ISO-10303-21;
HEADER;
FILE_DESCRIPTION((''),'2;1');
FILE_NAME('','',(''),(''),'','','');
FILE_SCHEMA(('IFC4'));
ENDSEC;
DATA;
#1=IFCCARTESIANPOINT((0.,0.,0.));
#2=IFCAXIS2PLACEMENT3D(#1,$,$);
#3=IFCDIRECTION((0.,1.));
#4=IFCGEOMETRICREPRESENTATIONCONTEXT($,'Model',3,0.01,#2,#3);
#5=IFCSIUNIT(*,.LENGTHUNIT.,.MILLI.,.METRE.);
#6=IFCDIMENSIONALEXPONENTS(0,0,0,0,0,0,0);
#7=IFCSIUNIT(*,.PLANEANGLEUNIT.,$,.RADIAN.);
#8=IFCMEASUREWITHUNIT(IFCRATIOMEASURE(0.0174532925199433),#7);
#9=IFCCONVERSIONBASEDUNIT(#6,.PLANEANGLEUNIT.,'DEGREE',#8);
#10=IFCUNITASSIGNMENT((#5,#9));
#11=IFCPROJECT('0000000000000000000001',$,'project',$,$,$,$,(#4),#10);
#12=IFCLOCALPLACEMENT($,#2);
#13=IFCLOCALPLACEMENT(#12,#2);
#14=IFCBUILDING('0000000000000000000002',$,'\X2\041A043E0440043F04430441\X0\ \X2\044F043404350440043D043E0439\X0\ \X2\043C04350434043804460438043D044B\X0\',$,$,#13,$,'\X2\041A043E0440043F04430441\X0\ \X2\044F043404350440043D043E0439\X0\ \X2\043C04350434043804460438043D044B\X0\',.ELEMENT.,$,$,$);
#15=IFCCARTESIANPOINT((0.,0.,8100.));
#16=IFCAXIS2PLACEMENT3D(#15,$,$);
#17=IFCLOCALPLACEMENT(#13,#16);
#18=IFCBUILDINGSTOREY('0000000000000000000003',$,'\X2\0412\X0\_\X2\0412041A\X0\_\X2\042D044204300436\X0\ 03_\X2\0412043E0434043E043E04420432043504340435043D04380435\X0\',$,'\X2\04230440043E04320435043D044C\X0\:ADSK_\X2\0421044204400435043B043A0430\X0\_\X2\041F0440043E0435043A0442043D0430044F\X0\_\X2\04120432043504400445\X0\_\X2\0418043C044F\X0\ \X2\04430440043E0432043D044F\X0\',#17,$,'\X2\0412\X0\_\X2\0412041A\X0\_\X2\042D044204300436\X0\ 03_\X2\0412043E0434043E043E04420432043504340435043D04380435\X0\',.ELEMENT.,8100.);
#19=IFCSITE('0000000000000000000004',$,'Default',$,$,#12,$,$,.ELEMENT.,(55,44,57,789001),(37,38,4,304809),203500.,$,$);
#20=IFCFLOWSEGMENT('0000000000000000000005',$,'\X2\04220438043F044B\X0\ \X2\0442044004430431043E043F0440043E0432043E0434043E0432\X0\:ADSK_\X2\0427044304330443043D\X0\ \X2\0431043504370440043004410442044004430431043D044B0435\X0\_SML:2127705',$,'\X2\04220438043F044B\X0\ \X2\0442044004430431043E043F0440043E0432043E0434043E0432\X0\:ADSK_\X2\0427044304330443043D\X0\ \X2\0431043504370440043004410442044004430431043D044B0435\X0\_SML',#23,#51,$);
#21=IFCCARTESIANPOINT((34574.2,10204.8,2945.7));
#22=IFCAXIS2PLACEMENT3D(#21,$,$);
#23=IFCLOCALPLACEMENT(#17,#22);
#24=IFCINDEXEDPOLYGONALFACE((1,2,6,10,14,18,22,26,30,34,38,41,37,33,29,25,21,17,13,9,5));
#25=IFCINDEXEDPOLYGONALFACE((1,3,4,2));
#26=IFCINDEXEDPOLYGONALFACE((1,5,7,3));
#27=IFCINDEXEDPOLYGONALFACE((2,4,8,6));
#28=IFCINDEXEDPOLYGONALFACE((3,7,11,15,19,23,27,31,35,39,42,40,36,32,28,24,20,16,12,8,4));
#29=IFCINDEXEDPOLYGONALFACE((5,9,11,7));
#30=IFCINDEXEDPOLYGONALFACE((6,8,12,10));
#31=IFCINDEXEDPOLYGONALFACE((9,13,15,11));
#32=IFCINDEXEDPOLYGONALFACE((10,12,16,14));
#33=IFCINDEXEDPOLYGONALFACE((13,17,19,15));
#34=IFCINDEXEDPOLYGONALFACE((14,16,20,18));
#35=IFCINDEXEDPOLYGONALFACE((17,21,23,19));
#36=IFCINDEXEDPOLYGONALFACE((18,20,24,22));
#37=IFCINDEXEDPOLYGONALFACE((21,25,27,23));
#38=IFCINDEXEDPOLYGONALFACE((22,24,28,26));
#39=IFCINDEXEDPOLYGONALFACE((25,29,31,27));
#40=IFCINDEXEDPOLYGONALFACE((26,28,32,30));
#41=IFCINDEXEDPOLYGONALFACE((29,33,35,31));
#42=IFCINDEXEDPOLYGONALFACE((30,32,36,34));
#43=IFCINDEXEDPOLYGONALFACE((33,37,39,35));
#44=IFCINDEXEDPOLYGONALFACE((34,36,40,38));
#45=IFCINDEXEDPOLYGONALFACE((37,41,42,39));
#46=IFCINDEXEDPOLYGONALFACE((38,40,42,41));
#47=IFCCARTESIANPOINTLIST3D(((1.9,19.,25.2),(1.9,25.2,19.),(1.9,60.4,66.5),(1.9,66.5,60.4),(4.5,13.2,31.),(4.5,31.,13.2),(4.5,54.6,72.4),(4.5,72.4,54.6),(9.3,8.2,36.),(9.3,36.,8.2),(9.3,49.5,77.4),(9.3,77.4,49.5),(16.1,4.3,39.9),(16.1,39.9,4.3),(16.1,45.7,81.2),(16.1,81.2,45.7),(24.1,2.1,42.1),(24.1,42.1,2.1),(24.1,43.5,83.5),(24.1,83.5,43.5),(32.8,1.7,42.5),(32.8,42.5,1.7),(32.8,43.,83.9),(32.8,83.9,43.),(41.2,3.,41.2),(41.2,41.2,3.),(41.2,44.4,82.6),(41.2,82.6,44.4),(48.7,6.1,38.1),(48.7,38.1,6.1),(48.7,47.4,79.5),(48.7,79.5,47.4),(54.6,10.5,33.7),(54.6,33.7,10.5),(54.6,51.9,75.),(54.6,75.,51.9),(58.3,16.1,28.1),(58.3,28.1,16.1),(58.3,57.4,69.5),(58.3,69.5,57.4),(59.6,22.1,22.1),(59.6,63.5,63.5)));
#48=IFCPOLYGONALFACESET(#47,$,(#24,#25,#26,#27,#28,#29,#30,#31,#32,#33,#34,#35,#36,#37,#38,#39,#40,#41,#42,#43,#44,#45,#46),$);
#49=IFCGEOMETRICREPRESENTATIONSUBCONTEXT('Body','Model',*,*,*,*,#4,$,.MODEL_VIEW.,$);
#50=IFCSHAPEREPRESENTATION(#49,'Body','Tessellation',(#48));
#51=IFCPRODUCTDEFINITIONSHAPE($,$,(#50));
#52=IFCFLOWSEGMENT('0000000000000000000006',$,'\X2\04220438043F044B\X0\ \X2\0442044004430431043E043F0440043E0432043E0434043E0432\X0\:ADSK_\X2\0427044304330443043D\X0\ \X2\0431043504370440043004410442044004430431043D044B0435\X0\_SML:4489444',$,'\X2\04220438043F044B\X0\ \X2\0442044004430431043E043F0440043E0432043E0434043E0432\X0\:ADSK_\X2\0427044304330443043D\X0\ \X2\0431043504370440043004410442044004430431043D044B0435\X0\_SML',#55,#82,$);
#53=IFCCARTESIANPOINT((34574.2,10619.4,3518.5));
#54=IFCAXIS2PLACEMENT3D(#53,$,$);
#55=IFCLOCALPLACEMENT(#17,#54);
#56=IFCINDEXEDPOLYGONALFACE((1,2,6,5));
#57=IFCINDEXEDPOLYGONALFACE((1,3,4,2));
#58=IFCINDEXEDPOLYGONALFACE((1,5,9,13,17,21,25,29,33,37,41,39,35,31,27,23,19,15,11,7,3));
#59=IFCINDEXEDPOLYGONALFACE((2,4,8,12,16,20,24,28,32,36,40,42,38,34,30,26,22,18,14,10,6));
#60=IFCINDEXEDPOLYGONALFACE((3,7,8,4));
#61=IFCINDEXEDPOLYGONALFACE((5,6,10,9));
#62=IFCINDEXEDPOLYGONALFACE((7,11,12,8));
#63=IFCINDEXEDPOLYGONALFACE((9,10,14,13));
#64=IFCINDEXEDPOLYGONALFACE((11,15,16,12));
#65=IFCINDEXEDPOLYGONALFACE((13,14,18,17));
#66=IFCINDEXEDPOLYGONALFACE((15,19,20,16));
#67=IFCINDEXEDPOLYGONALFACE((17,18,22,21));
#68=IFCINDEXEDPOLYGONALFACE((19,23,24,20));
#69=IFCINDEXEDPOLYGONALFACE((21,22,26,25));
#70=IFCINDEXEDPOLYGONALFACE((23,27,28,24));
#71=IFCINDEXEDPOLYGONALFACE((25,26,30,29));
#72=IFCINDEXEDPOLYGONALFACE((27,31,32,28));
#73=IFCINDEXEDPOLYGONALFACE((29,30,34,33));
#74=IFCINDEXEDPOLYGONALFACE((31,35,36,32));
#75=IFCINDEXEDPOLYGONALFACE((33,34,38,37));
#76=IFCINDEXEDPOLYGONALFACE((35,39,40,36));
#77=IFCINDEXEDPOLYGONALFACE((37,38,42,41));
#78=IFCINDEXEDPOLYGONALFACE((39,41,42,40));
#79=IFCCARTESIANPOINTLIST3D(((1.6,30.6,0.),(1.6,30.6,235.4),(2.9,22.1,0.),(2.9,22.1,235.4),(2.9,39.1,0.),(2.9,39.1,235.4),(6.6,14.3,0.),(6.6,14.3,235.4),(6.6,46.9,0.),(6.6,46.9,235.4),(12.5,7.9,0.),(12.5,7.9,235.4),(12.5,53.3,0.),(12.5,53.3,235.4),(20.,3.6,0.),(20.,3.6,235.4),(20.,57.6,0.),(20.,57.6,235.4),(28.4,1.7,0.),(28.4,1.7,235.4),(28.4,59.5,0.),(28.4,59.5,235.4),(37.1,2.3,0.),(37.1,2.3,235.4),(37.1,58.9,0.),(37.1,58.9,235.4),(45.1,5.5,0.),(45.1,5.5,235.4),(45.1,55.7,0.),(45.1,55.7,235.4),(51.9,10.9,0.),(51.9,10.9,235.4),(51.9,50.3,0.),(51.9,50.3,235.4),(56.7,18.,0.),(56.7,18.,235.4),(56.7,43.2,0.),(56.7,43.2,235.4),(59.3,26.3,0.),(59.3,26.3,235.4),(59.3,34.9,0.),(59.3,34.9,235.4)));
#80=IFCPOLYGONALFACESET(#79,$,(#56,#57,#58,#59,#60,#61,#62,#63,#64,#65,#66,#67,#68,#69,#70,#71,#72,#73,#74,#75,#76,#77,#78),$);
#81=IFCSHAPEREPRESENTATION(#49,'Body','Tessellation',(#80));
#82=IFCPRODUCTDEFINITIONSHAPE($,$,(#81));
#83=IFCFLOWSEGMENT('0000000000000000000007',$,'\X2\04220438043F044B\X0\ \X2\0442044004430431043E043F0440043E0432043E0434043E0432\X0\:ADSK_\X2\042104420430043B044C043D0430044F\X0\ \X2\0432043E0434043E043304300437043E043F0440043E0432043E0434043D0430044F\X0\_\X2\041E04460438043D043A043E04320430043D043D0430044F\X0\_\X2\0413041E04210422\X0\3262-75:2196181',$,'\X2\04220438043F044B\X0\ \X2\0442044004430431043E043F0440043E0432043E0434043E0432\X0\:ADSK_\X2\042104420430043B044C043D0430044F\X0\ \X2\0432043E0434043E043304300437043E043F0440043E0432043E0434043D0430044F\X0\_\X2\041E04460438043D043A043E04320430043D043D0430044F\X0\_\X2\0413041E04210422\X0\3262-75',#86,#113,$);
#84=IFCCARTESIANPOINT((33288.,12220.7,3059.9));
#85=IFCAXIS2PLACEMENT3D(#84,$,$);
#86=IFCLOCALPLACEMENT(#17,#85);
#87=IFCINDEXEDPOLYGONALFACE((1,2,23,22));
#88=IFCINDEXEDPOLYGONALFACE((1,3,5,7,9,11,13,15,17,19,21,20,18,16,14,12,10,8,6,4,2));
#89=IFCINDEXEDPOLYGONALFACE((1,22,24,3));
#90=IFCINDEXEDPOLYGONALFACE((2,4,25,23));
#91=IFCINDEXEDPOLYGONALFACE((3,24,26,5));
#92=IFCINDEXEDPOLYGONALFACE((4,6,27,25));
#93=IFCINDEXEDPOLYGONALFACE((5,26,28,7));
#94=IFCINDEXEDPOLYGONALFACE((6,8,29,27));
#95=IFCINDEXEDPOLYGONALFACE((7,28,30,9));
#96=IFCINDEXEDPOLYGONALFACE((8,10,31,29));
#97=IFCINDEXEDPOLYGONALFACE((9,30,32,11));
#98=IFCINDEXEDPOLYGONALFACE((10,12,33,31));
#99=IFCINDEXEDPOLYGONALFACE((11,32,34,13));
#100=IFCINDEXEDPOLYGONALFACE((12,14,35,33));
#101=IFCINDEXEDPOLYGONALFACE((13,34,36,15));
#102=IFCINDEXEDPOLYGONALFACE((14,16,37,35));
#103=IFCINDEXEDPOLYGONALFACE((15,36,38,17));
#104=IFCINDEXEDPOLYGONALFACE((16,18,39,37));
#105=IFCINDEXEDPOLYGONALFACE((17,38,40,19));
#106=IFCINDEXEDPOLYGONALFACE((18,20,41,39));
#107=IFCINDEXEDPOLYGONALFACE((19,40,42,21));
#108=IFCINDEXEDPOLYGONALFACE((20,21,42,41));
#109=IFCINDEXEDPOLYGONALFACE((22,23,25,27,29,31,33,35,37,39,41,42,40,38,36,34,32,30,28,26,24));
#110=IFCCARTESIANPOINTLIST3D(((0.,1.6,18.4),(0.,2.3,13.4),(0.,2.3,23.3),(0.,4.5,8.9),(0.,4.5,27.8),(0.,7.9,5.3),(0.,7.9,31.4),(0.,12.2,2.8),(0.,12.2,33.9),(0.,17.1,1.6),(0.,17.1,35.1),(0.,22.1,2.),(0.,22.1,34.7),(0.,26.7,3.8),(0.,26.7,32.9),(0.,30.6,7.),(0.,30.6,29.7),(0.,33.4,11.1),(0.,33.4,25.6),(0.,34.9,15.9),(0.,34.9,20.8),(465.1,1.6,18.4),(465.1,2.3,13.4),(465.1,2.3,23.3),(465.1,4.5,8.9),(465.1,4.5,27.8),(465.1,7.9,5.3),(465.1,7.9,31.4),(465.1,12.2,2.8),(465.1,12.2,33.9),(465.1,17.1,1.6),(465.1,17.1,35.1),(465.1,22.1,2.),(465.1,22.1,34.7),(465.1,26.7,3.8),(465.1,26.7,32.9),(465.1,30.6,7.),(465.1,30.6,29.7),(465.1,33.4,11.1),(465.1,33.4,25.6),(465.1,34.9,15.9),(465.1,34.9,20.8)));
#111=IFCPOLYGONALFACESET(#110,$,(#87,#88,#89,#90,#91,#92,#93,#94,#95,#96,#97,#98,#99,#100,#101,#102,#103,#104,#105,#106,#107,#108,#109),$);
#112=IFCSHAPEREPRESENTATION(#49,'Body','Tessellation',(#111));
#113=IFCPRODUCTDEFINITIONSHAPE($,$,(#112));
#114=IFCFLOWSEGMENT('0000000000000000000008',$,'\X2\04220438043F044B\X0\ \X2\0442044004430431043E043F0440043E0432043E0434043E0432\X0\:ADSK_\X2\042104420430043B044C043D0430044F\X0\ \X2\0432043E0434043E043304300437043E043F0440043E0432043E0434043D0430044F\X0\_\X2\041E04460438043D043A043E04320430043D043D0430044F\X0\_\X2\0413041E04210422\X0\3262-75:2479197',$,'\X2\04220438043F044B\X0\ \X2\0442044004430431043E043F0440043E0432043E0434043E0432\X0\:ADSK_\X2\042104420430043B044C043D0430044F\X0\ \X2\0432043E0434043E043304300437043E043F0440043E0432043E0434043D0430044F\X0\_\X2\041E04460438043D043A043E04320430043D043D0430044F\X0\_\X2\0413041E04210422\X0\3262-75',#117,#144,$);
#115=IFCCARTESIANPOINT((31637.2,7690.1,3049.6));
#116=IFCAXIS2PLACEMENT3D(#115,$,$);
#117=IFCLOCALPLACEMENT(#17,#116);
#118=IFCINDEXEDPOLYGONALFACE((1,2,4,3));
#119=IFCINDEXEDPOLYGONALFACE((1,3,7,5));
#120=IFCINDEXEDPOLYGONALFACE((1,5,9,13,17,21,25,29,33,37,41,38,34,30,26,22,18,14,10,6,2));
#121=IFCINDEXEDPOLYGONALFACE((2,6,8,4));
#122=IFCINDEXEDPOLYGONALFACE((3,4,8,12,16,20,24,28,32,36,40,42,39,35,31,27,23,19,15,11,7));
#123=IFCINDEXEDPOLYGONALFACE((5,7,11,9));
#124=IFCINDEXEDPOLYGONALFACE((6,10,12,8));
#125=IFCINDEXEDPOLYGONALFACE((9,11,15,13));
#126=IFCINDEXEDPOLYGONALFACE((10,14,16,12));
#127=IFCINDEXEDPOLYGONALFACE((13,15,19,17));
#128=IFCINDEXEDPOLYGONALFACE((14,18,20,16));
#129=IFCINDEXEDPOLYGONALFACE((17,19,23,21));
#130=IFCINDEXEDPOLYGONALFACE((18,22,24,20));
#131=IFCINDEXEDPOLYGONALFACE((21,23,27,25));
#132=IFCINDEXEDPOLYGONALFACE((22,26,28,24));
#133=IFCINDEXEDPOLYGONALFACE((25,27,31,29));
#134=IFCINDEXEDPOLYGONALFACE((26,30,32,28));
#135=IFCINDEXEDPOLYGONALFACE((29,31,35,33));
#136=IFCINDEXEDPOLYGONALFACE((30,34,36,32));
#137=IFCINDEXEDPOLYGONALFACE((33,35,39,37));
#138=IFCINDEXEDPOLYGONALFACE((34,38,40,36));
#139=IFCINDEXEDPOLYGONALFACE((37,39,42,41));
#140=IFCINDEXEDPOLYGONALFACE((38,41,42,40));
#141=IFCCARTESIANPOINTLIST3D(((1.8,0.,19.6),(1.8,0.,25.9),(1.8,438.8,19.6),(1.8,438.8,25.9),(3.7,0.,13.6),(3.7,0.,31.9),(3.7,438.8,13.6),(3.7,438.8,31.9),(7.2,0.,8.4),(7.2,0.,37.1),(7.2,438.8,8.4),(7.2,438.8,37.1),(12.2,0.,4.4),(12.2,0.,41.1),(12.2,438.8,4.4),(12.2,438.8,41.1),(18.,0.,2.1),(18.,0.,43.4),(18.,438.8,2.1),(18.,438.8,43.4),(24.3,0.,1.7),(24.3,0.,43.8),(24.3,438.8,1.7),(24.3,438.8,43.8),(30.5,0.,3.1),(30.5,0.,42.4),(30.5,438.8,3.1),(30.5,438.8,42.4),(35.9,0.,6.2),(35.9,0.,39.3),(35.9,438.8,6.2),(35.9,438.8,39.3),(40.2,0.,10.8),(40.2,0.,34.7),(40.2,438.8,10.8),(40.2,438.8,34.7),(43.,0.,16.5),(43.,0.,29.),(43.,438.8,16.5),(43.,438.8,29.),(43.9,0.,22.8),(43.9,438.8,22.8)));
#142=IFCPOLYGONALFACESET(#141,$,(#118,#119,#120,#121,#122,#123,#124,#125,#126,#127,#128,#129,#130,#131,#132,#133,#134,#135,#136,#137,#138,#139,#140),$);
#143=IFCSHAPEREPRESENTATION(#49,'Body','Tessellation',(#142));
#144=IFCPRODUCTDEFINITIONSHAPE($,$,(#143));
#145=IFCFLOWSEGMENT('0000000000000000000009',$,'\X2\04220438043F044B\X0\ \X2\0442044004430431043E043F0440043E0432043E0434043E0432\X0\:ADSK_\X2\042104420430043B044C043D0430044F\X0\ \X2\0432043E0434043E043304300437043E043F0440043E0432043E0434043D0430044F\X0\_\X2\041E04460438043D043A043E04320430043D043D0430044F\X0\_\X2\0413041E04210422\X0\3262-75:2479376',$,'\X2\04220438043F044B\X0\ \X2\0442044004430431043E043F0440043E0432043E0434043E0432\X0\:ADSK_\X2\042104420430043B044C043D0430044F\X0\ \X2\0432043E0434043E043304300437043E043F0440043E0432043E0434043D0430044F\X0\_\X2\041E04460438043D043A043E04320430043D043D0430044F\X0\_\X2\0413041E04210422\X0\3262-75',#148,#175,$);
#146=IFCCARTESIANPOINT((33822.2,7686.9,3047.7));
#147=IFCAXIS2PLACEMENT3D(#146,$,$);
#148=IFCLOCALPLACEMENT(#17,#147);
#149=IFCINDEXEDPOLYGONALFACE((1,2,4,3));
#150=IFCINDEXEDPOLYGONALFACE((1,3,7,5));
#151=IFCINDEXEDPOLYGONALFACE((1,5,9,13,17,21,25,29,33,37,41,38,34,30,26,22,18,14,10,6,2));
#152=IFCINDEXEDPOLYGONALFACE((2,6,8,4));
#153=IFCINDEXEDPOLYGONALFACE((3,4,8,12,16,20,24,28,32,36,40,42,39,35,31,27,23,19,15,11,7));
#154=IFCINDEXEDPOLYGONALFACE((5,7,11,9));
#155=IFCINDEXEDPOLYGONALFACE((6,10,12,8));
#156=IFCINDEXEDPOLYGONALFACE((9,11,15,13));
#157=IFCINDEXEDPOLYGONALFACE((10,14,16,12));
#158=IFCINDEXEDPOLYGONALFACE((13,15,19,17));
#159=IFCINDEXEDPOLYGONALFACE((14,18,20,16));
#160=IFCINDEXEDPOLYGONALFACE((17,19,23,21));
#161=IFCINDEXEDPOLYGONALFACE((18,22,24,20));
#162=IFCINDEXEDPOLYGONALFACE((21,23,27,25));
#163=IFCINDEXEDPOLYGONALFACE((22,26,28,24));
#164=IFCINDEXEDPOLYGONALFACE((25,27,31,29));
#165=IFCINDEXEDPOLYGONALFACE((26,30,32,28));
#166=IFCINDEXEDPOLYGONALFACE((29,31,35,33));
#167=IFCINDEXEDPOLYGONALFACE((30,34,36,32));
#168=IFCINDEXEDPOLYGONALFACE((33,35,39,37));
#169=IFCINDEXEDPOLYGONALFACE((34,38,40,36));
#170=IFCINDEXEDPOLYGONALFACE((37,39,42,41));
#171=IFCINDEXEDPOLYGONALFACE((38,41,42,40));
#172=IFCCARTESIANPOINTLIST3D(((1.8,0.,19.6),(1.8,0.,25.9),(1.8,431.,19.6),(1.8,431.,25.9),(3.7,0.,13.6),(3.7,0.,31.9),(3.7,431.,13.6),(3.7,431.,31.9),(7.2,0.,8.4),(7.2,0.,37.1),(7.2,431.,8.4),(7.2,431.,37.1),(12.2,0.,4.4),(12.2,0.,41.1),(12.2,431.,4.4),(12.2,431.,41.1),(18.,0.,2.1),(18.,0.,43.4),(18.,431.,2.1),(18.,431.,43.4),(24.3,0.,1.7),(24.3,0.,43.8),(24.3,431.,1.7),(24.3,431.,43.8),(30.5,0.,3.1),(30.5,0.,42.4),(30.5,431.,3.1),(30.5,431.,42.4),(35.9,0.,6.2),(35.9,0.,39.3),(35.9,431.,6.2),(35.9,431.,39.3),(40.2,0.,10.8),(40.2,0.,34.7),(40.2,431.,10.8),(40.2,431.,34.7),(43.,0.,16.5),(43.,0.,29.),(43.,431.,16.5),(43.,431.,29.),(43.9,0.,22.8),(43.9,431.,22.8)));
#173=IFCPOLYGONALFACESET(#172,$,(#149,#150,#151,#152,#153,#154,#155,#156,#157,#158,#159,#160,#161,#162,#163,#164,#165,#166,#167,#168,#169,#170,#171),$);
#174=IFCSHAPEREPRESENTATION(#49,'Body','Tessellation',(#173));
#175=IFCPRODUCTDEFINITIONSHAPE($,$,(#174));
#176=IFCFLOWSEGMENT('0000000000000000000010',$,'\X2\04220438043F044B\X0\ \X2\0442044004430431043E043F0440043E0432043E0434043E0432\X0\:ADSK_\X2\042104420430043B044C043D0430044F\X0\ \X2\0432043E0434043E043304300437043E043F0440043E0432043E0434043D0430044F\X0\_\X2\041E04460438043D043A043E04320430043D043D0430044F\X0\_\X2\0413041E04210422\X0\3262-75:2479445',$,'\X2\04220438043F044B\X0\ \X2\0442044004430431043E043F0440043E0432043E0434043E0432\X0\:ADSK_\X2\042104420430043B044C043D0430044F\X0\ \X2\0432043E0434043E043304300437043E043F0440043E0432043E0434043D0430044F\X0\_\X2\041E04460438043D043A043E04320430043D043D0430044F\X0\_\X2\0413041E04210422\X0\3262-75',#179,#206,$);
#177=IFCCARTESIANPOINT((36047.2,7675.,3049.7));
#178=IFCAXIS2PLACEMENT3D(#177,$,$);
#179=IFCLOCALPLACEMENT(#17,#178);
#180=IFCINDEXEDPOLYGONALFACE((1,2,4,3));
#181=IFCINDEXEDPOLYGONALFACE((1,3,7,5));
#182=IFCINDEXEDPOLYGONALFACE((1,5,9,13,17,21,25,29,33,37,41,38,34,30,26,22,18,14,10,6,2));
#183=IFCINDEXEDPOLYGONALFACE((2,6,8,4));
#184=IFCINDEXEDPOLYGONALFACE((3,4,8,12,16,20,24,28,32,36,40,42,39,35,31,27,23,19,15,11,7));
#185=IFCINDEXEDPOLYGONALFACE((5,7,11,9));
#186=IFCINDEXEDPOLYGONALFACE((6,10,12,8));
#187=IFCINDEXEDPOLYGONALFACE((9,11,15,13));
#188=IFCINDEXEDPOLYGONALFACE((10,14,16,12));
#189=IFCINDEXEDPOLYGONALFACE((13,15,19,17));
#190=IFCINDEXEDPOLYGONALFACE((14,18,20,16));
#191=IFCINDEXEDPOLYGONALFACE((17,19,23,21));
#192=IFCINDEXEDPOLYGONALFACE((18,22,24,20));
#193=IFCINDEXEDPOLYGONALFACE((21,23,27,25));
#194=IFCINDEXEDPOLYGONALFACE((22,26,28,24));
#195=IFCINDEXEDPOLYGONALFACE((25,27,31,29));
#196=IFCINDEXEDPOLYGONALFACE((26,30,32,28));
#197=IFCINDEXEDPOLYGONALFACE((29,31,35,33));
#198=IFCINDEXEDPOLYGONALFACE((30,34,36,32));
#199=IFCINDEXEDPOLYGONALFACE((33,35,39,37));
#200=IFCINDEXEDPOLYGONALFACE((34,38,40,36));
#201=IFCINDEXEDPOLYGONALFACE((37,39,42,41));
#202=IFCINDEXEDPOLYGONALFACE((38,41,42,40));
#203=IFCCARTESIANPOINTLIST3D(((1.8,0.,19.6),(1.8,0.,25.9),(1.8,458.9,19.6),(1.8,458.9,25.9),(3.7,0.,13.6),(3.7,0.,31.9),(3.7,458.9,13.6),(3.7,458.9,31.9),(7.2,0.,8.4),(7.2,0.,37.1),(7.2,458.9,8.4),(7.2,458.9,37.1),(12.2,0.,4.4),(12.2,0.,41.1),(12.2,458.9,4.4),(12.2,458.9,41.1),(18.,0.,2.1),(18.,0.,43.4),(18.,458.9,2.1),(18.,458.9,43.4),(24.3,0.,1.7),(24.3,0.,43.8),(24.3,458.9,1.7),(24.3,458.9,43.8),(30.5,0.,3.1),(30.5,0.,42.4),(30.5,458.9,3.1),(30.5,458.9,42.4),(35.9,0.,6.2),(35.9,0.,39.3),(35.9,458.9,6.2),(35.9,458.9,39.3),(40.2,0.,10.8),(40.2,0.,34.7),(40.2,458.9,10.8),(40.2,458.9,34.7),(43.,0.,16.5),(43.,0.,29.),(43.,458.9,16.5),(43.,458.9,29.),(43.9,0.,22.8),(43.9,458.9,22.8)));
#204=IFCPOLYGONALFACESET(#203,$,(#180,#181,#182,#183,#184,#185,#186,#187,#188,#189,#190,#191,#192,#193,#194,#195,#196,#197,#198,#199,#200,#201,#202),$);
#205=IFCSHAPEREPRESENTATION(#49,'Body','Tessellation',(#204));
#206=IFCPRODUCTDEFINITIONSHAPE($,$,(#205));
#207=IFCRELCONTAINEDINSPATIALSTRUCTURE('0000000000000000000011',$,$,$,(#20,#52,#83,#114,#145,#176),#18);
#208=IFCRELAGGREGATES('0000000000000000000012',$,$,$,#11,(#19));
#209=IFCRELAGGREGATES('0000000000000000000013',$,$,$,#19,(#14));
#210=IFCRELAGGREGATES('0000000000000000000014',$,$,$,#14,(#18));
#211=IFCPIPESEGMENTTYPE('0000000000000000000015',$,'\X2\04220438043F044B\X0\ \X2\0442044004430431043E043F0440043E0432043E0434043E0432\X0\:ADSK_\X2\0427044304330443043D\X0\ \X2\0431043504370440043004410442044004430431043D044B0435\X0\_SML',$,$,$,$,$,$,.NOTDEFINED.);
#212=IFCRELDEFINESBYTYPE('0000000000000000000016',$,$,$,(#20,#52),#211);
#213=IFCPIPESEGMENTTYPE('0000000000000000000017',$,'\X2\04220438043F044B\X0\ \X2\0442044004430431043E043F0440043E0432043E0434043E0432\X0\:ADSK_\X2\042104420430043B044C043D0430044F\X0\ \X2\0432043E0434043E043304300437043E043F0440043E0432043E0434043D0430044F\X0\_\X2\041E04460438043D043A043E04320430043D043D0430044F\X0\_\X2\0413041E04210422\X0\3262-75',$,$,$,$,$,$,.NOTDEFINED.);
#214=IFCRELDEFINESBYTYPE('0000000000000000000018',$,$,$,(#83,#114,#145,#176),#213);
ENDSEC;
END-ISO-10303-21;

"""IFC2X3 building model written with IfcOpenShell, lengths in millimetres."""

from ifc_helpers import new_model, entity, si_unit, converted_unit, direction, frame, origin, origin_2d_with_axis, place, context, subcontext, project, spatial, circle, extrude, type_object, element, save


model = new_model("IFC2X3")

# Units and contexts
model_context = context("Model", 3, precision=0.01, world=origin(), true_north=direction((0.0, 1.0)))
body_context = subcontext(model_context, "Body", "Model", "MODEL_VIEW")
ifc_project = project(units=[si_unit("LENGTHUNIT", "METRE", prefix="MILLI"), converted_unit("PLANEANGLEUNIT", "DEGREE", entity("IfcRatioMeasure", 0.0174532925199433), si_unit("PLANEANGLEUNIT", "RADIAN"), dimensions=[0, 0, 0, 0, 0, 0, 0])], contexts=[model_context])

# Site, building, storey
site_placement = place(None, origin())
site = spatial("IfcSite", under=ifc_project, at=site_placement, Name="Default", CompositionType="ELEMENT", RefLatitude=(55, 44, 57, 789001), RefLongitude=(37, 38, 4, 304809), RefElevation=203500.0)
building_placement = place(site_placement, origin())
building = spatial("IfcBuilding", under=site, at=building_placement, Name="Корпус ядерной медицины", LongName="Корпус ядерной медицины", CompositionType="ELEMENT")
storey_placement = place(building_placement, frame((0.0, 0.0, 8100.0)))
storey = spatial("IfcBuildingStorey", under=building, at=storey_placement, Name="В_ВК_Этаж 03_Водоотведение", ObjectType="Уровень:ADSK_Стрелка_Проектная_Вверх_Имя уровня", LongName="В_ВК_Этаж 03_Водоотведение", CompositionType="ELEMENT", Elevation=8100.0)

# Flow segments
pipe_segment_type_1 = type_object("IfcPipeSegmentType", Name="Типы трубопроводов:ADSK_Чугун безраструбные_SML", PredefinedType="NOTDEFINED")
flow_segment_1_placement = place(storey_placement, frame((34574.2, 10204.8, 2945.7)))
element("IfcFlowSegment", 1, at=flow_segment_1_placement, inside=storey, type_object=pipe_segment_type_1, Name="Типы трубопроводов:ADSK_Чугун безраструбные_SML:2127705", ObjectType="Типы трубопроводов:ADSK_Чугун безраструбные_SML", context=body_context, shape_type="SweptSolid", body=[
    extrude(circle(Radius=29.0, at=origin_2d_with_axis()), frame((30.6, 22.1, 22.1), z_axis=(0.0, 0.707107, 0.707107), x_axis=(1.0, 0.0, 0.0)), (0.0, 0.0, 1.0), 58.5),
])
flow_segment_2_placement = place(storey_placement, frame((34574.2, 10619.4, 3518.5)))
element("IfcFlowSegment", 2, at=flow_segment_2_placement, inside=storey, type_object=pipe_segment_type_1, Name="Типы трубопроводов:ADSK_Чугун безраструбные_SML:4489444", ObjectType="Типы трубопроводов:ADSK_Чугун безраструбные_SML", context=body_context, shape_type="SweptSolid", body=[
    extrude(circle(Radius=29.0, at=origin_2d_with_axis()), frame((30.6, 30.6, 0.0), z_axis=(0.0, 0.0, 1.0), x_axis=(-1.0, 0.0, 0.0)), (0.0, 0.0, 1.0), 235.4),
])
pipe_segment_type_2 = type_object("IfcPipeSegmentType", Name="Типы трубопроводов:ADSK_Стальная водогазопроводная_Оцинкованная_ГОСТ3262-75", PredefinedType="NOTDEFINED")
flow_segment_3_placement = place(storey_placement, frame((33288.0, 12220.7, 3059.9)))
element("IfcFlowSegment", 3, at=flow_segment_3_placement, inside=storey, type_object=pipe_segment_type_2, Name="Типы трубопроводов:ADSK_Стальная водогазопроводная_Оцинкованная_ГОСТ3262-75:2196181", ObjectType="Типы трубопроводов:ADSK_Стальная водогазопроводная_Оцинкованная_ГОСТ3262-75", context=body_context, shape_type="SweptSolid", body=[
    extrude(circle(Radius=16.8, at=origin_2d_with_axis()), frame((0.0, 18.4, 18.4), z_axis=(1.0, 0.0, 0.0), x_axis=(0.0, -1.0, 0.0)), (0.0, 0.0, 1.0), 465.1),
])
flow_segment_4_placement = place(storey_placement, frame((31637.2, 7690.1, 3049.6)))
element("IfcFlowSegment", 4, at=flow_segment_4_placement, inside=storey, type_object=pipe_segment_type_2, Name="Типы трубопроводов:ADSK_Стальная водогазопроводная_Оцинкованная_ГОСТ3262-75:2479197", ObjectType="Типы трубопроводов:ADSK_Стальная водогазопроводная_Оцинкованная_ГОСТ3262-75", context=body_context, shape_type="SweptSolid", body=[
    extrude(circle(Radius=21.1, at=origin_2d_with_axis()), frame((22.8, 0.0, 22.8), z_axis=(0.0, 1.0, 0.0), x_axis=(1.0, 0.0, 0.0)), (0.0, 0.0, 1.0), 438.8),
])
flow_segment_5_placement = place(storey_placement, frame((33822.2, 7686.9, 3047.7)))
element("IfcFlowSegment", 5, at=flow_segment_5_placement, inside=storey, type_object=pipe_segment_type_2, Name="Типы трубопроводов:ADSK_Стальная водогазопроводная_Оцинкованная_ГОСТ3262-75:2479376", ObjectType="Типы трубопроводов:ADSK_Стальная водогазопроводная_Оцинкованная_ГОСТ3262-75", context=body_context, shape_type="SweptSolid", body=[
    extrude(circle(Radius=21.1, at=origin_2d_with_axis()), frame((22.8, 0.0, 22.8), z_axis=(0.0, 1.0, 0.0), x_axis=(1.0, 0.0, 0.0)), (0.0, 0.0, 1.0), 431.0),
])
flow_segment_6_placement = place(storey_placement, frame((36047.2, 7675.0, 3049.7)))
element("IfcFlowSegment", 6, at=flow_segment_6_placement, inside=storey, type_object=pipe_segment_type_2, Name="Типы трубопроводов:ADSK_Стальная водогазопроводная_Оцинкованная_ГОСТ3262-75:2479445", ObjectType="Типы трубопроводов:ADSK_Стальная водогазопроводная_Оцинкованная_ГОСТ3262-75", context=body_context, shape_type="SweptSolid", body=[
    extrude(circle(Radius=21.1, at=origin_2d_with_axis()), frame((22.8, 0.0, 22.8), z_axis=(0.0, 1.0, 0.0), x_axis=(1.0, 0.0, 0.0)), (0.0, 0.0, 1.0), 458.9),
])

save(model, "model.ifc")
